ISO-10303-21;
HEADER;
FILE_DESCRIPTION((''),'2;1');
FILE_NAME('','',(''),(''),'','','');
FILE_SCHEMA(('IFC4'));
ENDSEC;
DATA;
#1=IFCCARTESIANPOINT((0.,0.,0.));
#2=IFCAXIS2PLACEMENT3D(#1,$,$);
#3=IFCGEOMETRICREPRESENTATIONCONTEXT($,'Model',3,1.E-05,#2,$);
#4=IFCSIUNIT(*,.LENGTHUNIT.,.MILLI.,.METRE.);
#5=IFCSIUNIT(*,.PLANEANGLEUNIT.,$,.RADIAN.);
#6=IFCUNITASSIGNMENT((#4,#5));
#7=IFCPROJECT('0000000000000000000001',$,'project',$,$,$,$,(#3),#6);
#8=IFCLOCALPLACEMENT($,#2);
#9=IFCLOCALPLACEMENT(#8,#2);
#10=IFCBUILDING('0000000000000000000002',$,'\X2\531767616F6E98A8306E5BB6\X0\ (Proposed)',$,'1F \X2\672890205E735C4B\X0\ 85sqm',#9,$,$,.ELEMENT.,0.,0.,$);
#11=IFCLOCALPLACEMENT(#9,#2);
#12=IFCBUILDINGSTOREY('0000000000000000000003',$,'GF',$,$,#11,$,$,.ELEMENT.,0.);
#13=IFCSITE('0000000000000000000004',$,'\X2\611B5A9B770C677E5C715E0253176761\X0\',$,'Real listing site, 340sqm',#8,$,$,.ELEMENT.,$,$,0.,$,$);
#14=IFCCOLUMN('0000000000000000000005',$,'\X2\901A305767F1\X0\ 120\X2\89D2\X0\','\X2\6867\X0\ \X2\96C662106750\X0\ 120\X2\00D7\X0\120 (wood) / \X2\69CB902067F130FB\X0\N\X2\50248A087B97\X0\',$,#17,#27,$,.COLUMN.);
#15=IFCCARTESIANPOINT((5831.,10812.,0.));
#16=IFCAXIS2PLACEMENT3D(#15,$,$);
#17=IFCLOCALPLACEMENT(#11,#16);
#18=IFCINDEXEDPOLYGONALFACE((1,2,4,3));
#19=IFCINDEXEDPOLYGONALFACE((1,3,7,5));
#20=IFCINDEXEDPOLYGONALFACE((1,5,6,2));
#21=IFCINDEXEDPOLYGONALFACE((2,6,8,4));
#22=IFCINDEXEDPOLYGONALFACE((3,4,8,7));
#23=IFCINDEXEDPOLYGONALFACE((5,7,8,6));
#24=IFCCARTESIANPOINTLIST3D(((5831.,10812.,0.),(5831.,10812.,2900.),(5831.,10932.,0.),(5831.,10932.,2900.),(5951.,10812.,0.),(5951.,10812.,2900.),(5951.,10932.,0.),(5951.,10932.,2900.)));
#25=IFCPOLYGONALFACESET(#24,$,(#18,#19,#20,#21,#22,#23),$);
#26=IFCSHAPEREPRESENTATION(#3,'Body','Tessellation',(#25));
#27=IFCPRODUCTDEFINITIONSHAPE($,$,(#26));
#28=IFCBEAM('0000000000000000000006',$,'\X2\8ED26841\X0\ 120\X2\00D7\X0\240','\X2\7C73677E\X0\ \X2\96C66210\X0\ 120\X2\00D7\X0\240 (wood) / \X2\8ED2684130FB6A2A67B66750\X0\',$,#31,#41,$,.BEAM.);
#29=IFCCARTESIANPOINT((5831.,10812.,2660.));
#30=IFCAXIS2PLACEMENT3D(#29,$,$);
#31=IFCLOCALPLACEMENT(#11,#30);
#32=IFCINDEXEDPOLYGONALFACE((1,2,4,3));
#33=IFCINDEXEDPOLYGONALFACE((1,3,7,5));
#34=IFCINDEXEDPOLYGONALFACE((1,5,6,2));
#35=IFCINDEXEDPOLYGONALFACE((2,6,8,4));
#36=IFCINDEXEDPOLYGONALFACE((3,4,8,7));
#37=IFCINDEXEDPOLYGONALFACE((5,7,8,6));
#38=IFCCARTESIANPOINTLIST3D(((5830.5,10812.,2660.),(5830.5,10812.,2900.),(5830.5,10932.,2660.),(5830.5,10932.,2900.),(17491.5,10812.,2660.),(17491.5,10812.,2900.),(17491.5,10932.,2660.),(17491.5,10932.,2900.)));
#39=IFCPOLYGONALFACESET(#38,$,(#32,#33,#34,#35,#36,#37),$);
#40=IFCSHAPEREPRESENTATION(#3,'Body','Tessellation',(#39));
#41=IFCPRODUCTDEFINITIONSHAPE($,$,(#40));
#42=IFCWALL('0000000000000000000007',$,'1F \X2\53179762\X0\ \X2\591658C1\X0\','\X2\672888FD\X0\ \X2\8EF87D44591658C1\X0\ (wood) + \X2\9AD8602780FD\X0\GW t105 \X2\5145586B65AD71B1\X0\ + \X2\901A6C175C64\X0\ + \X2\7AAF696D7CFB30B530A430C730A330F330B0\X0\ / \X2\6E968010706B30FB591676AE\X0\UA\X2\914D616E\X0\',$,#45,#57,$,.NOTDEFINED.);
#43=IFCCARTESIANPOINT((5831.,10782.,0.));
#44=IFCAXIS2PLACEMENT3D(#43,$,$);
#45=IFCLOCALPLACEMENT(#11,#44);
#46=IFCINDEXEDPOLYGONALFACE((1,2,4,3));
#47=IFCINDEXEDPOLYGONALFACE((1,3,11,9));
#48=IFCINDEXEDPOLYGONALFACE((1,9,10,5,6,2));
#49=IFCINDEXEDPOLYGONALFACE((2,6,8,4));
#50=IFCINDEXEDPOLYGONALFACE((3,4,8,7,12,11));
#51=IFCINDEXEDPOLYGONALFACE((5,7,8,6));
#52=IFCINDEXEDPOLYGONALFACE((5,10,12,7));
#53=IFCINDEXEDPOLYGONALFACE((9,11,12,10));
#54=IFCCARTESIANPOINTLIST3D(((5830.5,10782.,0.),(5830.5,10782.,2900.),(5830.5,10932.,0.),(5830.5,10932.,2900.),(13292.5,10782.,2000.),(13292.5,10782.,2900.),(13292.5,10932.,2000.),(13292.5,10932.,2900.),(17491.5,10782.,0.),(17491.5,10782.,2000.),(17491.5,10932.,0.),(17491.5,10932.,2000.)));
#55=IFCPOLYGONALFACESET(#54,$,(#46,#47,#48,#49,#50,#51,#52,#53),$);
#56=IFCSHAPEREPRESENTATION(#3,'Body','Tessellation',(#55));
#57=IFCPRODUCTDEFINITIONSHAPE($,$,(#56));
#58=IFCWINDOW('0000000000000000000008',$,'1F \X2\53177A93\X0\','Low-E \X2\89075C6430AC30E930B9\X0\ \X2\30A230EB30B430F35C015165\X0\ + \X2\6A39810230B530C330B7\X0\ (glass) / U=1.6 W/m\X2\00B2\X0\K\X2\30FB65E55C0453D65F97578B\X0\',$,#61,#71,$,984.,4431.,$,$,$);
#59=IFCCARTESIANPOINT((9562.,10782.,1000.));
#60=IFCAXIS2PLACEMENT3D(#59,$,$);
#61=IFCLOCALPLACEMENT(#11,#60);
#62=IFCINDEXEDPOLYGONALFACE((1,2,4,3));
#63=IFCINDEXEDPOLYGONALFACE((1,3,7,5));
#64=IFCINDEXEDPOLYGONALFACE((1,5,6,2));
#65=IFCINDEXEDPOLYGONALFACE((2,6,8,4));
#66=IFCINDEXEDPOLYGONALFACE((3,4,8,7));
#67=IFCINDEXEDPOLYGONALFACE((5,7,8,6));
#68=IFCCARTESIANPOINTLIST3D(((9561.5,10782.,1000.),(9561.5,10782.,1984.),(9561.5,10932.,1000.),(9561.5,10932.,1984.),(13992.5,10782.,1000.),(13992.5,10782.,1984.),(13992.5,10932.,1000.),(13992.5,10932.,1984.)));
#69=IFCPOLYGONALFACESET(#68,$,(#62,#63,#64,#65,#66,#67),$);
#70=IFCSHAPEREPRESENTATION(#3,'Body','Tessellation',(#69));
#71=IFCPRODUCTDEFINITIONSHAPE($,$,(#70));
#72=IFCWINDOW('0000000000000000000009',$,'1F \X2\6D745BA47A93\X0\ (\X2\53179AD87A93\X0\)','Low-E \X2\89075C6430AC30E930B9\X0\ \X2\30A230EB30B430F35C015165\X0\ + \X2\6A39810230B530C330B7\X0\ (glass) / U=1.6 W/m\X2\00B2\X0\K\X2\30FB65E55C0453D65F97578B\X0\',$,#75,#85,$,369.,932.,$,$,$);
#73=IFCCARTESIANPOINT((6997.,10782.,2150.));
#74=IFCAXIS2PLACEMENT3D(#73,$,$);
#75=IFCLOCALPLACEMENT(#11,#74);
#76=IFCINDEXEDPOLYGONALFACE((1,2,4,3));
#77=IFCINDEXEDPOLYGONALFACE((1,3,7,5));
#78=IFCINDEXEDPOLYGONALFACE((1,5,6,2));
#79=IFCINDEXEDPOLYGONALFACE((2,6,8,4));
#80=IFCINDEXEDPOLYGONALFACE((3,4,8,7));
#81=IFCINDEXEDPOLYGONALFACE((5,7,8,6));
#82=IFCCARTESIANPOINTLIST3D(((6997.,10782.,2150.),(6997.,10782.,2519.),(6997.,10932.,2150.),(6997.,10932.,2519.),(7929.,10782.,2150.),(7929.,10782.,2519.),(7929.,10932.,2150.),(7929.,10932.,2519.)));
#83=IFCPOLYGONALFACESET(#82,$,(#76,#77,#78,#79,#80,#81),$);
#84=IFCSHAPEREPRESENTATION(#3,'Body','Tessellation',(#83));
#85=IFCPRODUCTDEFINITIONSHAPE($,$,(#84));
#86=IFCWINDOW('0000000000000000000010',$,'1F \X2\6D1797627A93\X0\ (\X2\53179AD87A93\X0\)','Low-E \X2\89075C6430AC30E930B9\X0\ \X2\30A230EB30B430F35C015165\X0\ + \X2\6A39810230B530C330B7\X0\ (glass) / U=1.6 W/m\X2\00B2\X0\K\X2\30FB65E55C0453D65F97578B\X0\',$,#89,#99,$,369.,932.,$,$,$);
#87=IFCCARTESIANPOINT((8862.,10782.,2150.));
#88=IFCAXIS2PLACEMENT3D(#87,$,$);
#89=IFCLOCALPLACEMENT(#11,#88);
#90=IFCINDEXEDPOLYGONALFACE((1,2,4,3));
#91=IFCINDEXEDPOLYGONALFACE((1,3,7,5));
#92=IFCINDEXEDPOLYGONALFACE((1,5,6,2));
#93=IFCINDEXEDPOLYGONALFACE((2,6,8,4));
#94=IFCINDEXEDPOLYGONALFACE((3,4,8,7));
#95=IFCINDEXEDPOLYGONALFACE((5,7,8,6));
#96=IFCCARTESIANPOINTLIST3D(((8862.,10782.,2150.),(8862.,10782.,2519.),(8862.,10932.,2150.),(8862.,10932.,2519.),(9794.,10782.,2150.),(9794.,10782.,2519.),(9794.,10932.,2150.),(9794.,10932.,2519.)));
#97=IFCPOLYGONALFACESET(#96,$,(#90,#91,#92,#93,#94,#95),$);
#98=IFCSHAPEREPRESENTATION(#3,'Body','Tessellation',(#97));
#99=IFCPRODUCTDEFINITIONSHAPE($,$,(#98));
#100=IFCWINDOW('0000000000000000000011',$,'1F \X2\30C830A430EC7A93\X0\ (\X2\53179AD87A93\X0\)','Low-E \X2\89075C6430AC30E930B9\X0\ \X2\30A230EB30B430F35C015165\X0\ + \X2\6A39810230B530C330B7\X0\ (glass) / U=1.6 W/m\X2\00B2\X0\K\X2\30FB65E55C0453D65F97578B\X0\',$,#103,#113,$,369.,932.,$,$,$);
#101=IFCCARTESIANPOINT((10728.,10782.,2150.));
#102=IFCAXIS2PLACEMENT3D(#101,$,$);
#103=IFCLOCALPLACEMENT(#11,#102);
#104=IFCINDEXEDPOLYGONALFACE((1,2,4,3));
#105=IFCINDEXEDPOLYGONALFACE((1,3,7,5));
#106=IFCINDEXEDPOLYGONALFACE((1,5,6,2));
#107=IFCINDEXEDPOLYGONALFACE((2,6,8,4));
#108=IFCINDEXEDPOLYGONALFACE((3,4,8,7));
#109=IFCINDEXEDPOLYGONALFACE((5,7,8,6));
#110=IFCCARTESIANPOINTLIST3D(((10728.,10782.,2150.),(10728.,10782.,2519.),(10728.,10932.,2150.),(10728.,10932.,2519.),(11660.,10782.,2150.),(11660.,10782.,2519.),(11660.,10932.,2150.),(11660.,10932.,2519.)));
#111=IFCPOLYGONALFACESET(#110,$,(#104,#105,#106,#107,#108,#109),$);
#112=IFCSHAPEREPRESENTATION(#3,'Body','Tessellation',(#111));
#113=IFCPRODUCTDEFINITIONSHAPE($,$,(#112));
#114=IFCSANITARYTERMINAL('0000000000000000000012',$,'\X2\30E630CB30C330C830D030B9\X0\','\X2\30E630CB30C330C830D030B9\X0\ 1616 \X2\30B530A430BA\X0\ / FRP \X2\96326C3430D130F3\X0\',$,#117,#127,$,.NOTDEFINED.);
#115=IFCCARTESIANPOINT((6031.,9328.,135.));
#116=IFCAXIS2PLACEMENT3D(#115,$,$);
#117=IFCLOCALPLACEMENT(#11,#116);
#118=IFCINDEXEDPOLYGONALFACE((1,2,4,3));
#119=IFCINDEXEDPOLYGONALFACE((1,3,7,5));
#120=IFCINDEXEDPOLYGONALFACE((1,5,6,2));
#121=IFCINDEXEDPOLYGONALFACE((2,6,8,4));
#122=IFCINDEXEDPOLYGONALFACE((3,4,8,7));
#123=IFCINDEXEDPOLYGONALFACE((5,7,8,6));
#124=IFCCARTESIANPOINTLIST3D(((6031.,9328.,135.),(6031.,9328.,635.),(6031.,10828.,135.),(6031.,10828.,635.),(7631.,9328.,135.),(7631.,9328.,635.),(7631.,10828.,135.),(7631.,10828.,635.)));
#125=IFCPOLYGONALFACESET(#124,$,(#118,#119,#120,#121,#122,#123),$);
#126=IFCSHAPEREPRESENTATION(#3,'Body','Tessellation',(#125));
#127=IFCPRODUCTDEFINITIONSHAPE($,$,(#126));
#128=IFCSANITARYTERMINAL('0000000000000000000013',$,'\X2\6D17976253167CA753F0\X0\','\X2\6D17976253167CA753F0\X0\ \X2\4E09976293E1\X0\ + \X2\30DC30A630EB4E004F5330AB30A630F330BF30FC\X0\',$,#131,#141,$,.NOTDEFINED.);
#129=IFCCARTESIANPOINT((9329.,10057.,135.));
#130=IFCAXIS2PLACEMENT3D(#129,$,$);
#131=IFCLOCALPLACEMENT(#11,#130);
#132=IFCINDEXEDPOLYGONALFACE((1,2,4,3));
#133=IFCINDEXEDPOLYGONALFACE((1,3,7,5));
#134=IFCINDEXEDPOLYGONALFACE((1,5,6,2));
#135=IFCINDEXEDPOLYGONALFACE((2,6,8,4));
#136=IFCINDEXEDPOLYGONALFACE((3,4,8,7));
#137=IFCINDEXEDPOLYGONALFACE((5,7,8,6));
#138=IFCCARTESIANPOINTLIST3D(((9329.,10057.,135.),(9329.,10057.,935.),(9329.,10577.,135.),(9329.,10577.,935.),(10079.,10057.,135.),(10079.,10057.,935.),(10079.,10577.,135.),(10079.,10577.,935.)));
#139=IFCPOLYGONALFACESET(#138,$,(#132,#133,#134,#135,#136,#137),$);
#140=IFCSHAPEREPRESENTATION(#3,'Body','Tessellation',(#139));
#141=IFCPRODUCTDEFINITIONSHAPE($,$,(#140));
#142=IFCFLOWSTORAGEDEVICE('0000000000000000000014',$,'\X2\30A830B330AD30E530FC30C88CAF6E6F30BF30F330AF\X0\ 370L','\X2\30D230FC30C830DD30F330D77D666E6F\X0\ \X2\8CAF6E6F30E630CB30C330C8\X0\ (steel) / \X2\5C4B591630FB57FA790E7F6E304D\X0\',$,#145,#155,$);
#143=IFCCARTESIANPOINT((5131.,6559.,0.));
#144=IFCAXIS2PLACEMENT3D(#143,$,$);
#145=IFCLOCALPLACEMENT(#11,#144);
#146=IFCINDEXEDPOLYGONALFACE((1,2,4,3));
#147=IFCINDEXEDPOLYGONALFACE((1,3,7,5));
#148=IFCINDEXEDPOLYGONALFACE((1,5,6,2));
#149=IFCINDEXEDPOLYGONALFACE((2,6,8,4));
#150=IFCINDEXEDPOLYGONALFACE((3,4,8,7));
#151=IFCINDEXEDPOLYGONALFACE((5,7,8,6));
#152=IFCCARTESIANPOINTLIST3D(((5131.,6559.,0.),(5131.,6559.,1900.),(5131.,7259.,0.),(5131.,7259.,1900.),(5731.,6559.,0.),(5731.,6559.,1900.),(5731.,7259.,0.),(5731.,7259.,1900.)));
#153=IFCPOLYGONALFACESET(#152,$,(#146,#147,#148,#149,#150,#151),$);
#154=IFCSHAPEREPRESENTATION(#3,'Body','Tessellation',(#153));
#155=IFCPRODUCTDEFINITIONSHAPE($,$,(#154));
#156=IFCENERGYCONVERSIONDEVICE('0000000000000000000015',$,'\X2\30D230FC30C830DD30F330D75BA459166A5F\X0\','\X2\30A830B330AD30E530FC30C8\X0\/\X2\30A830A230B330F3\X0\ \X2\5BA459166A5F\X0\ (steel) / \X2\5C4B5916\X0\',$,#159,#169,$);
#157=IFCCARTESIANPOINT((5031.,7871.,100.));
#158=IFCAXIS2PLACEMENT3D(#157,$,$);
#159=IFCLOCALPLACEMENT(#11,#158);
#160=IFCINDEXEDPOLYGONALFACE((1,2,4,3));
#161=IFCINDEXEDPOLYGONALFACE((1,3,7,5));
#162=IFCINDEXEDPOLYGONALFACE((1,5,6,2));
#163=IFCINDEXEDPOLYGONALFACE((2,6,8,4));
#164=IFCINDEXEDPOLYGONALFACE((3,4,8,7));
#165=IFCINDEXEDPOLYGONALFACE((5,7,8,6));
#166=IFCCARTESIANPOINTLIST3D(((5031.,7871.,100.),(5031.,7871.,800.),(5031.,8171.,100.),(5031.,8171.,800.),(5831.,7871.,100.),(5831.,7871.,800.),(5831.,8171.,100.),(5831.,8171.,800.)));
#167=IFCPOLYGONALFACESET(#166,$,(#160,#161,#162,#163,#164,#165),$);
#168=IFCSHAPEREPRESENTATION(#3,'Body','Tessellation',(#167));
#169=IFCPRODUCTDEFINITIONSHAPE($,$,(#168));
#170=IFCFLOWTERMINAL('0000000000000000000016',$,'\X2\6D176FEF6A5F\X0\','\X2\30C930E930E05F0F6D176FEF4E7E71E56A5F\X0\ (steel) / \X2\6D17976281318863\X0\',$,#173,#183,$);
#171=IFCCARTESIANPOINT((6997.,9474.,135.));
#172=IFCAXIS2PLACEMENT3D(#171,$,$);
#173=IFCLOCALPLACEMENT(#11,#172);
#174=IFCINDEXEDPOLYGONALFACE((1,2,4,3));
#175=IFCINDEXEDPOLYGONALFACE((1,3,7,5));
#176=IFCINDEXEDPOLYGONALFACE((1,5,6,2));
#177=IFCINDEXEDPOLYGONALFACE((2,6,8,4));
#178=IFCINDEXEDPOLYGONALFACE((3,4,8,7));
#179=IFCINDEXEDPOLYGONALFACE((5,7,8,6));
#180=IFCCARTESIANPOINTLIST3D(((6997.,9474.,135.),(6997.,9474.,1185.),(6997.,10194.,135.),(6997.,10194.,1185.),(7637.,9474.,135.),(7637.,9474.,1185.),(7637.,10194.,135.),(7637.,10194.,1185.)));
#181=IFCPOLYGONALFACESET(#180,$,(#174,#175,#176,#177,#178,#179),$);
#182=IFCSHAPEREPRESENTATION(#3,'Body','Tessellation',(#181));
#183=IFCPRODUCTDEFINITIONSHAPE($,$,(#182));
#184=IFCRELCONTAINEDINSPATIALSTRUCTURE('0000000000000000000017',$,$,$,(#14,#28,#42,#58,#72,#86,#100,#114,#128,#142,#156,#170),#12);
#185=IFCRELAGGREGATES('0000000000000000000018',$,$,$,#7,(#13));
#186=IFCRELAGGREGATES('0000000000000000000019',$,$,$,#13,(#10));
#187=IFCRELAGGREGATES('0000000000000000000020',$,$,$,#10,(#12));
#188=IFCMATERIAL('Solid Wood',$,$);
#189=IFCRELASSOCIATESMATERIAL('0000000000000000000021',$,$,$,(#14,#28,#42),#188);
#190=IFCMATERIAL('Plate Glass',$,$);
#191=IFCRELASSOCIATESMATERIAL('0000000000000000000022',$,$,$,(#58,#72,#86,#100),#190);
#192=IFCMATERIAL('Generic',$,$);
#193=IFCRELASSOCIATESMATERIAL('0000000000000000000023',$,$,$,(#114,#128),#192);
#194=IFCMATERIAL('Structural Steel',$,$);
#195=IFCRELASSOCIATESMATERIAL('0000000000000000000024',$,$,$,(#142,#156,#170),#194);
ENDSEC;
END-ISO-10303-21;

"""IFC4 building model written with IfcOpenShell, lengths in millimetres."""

from ifc_helpers import new_model, si_unit, frame, frame_2d, origin, place, context, project, spatial, rectangle, extrude, material, element, fill, save


model = new_model("IFC4")

# Units and contexts
model_context = context("Model", 3, precision=1e-05, world=origin())
ifc_project = project(units=[si_unit("LENGTHUNIT", "METRE", prefix="MILLI"), si_unit("PLANEANGLEUNIT", "RADIAN")], contexts=[model_context])

# Site, building, storey
site_placement = place(None, origin())
site = spatial("IfcSite", under=ifc_project, at=site_placement, Name="愛媛県松山市北条", ObjectType="Real listing site, 340sqm", CompositionType="ELEMENT", RefElevation=0.0)
building_placement = place(site_placement, origin())
building = spatial("IfcBuilding", under=site, at=building_placement, Name="北条潮風の家 (Proposed)", ObjectType="1F 木造平屋 85sqm", CompositionType="ELEMENT", ElevationOfRefHeight=0.0, ElevationOfTerrain=0.0)
storey_placement = place(building_placement, origin())
storey = spatial("IfcBuildingStorey", under=building, at=storey_placement, Name="GF", CompositionType="ELEMENT", Elevation=0.0)

# Column
ifc_material_1 = material(Name="Solid Wood")
column_1_placement = place(storey_placement, frame((5831.0, 10812.0, 0.0)))
element("IfcColumn", 1, at=column_1_placement, inside=storey, material=ifc_material_1, Name="通し柱 120角", Description="桧 集成材 120×120 (wood) / 構造柱・N値計算", PredefinedType="COLUMN", context=model_context, shape_type="SweptSolid", body=[
    extrude(rectangle(XDim=120.0, YDim=120.0, at=frame_2d((60.0, 60.0))), frame((5831.0, 10812.0, 0.0)), (0.0, 0.0, 1.0), 2900.0),
])

# Beam
beam_1_placement = place(storey_placement, frame((5831.0, 10812.0, 2660.0)))
element("IfcBeam", 2, at=beam_1_placement, inside=storey, material=ifc_material_1, Name="軒桁 120×240", Description="米松 集成 120×240 (wood) / 軒桁・横架材", PredefinedType="BEAM", context=model_context, shape_type="SweptSolid", body=[
    extrude(rectangle(XDim=11661.0, YDim=120.0, at=frame_2d((5830.0, 60.0))), frame((5831.0, 10812.0, 2660.0)), (0.0, 0.0, 1.0), 240.0),
])

# Wall, openings, windows
wall_1_placement = place(storey_placement, frame((5831.0, 10782.0, 0.0)))
wall_1 = element("IfcWall", 3, at=wall_1_placement, inside=storey, material=ifc_material_1, Name="1F 北面 外壁", Description="木製 軸組外壁 (wood) + 高性能GW t105 充填断熱 + 通気層 + 窯業系サイディング / 準耐火・外皮UA配慮", PredefinedType="NOTDEFINED", context=model_context, shape_type="SweptSolid", body=[
    extrude(rectangle(XDim=11661.0, YDim=150.0, at=frame_2d((5830.0, 75.0))), frame((5831.0, 10782.0, 0.0)), (0.0, 0.0, 1.0), 2900.0),
])
opening_1_placement = place(storey_placement, frame((9562.0, 10782.0, 1000.0)))
opening_1 = element("IfcOpeningElement", 4, at=opening_1_placement, cuts=wall_1, PredefinedType="NOTDEFINED", context=model_context, shape_type="SweptSolid", body=[
    extrude(rectangle(XDim=4431.0, YDim=150.0, at=frame_2d((2215.0, 75.0))), frame((9562.0, 10782.0, 1000.0)), (0.0, 0.0, 1.0), 984.0),
])
opening_2_placement = place(storey_placement, frame((6997.0, 10782.0, 2150.0)))
opening_2 = element("IfcOpeningElement", 5, at=opening_2_placement, cuts=wall_1, PredefinedType="NOTDEFINED", context=model_context, shape_type="SweptSolid", body=[
    extrude(rectangle(XDim=932.0, YDim=150.0, at=frame_2d((466.0, 75.0))), frame((6997.0, 10782.0, 2150.0)), (0.0, 0.0, 1.0), 369.0),
])
opening_3_placement = place(storey_placement, frame((8862.0, 10782.0, 2150.0)))
opening_3 = element("IfcOpeningElement", 6, at=opening_3_placement, cuts=wall_1, PredefinedType="NOTDEFINED", context=model_context, shape_type="SweptSolid", body=[
    extrude(rectangle(XDim=932.0, YDim=150.0, at=frame_2d((466.0, 75.0))), frame((8862.0, 10782.0, 2150.0)), (0.0, 0.0, 1.0), 369.0),
])
opening_4_placement = place(storey_placement, frame((10728.0, 10782.0, 2150.0)))
opening_4 = element("IfcOpeningElement", 7, at=opening_4_placement, cuts=wall_1, PredefinedType="NOTDEFINED", context=model_context, shape_type="SweptSolid", body=[
    extrude(rectangle(XDim=932.0, YDim=150.0, at=frame_2d((466.0, 75.0))), frame((10728.0, 10782.0, 2150.0)), (0.0, 0.0, 1.0), 369.0),
])
ifc_material_2 = material(Name="Plate Glass")
window_1_placement = place(storey_placement, frame((9562.0, 10782.0, 1000.0)))
window_1 = element("IfcWindow", 8, at=window_1_placement, inside=storey, material=ifc_material_2, Name="1F 北窓", Description="Low-E 複層ガラス アルゴン封入 + 樹脂サッシ (glass) / U=1.6 W/m²K・日射取得型", OverallHeight=984.0, OverallWidth=4431.0, context=model_context, shape_type="SweptSolid", body=[
    extrude(rectangle(XDim=4431.0, YDim=150.0, at=frame_2d((2215.0, 75.0))), frame((9562.0, 10782.0, 1000.0)), (0.0, 0.0, 1.0), 984.0),
])
fill(opening_1, window_1)
window_2_placement = place(storey_placement, frame((6997.0, 10782.0, 2150.0)))
window_2 = element("IfcWindow", 9, at=window_2_placement, inside=storey, material=ifc_material_2, Name="1F 浴室窓 (北高窓)", Description="Low-E 複層ガラス アルゴン封入 + 樹脂サッシ (glass) / U=1.6 W/m²K・日射取得型", OverallHeight=369.0, OverallWidth=932.0, context=model_context, shape_type="SweptSolid", body=[
    extrude(rectangle(XDim=932.0, YDim=150.0, at=frame_2d((466.0, 75.0))), frame((6997.0, 10782.0, 2150.0)), (0.0, 0.0, 1.0), 369.0),
])
fill(opening_2, window_2)
window_3_placement = place(storey_placement, frame((8862.0, 10782.0, 2150.0)))
window_3 = element("IfcWindow", 10, at=window_3_placement, inside=storey, material=ifc_material_2, Name="1F 洗面窓 (北高窓)", Description="Low-E 複層ガラス アルゴン封入 + 樹脂サッシ (glass) / U=1.6 W/m²K・日射取得型", OverallHeight=369.0, OverallWidth=932.0, context=model_context, shape_type="SweptSolid", body=[
    extrude(rectangle(XDim=932.0, YDim=150.0, at=frame_2d((466.0, 75.0))), frame((8862.0, 10782.0, 2150.0)), (0.0, 0.0, 1.0), 369.0),
])
fill(opening_3, window_3)
window_4_placement = place(storey_placement, frame((10728.0, 10782.0, 2150.0)))
window_4 = element("IfcWindow", 11, at=window_4_placement, inside=storey, material=ifc_material_2, Name="1F トイレ窓 (北高窓)", Description="Low-E 複層ガラス アルゴン封入 + 樹脂サッシ (glass) / U=1.6 W/m²K・日射取得型", OverallHeight=369.0, OverallWidth=932.0, context=model_context, shape_type="SweptSolid", body=[
    extrude(rectangle(XDim=932.0, YDim=150.0, at=frame_2d((466.0, 75.0))), frame((10728.0, 10782.0, 2150.0)), (0.0, 0.0, 1.0), 369.0),
])
fill(opening_4, window_4)

# Sanitary terminals
ifc_material_3 = material(Name="Generic")
sanitary_terminal_1_placement = place(storey_placement, frame((6031.0, 9328.0, 135.0)))
element("IfcSanitaryTerminal", 12, at=sanitary_terminal_1_placement, inside=storey, material=ifc_material_3, Name="ユニットバス", Description="ユニットバス 1616 サイズ / FRP 防水パン", PredefinedType="NOTDEFINED", context=model_context, shape_type="SweptSolid", body=[
    extrude(rectangle(XDim=1600.0, YDim=1500.0, at=frame_2d((800.0, 750.0))), frame((6031.0, 9328.0, 135.0)), (0.0, 0.0, 1.0), 500.0),
])
sanitary_terminal_2_placement = place(storey_placement, frame((9329.0, 10057.0, 135.0)))
element("IfcSanitaryTerminal", 13, at=sanitary_terminal_2_placement, inside=storey, material=ifc_material_3, Name="洗面化粧台", Description="洗面化粧台 三面鏡 + ボウル一体カウンター", PredefinedType="NOTDEFINED", context=model_context, shape_type="SweptSolid", body=[
    extrude(rectangle(XDim=750.0, YDim=520.0, at=frame_2d((375.0, 260.0))), frame((9329.0, 10057.0, 135.0)), (0.0, 0.0, 1.0), 800.0),
])

# Flow storage device
ifc_material_4 = material(Name="Structural Steel")
flow_storage_device_placement = place(storey_placement, frame((5131.0, 6559.0, 0.0)))
element("IfcFlowStorageDevice", 14, at=flow_storage_device_placement, inside=storey, material=ifc_material_4, Name="エコキュート貯湯タンク 370L", Description="ヒートポンプ給湯 貯湯ユニット (steel) / 屋外・基礎置き", context=model_context, shape_type="SweptSolid", body=[
    extrude(rectangle(XDim=600.0, YDim=700.0, at=frame_2d((300.0, 350.0))), frame((5131.0, 6559.0, 0.0)), (0.0, 0.0, 1.0), 1900.0),
])

# Energy conversion device
energy_conversion_device_placement = place(storey_placement, frame((5031.0, 7871.0, 100.0)))
element("IfcEnergyConversionDevice", 15, at=energy_conversion_device_placement, inside=storey, material=ifc_material_4, Name="ヒートポンプ室外機", Description="エコキュート/エアコン 室外機 (steel) / 屋外", context=model_context, shape_type="SweptSolid", body=[
    extrude(rectangle(XDim=800.0, YDim=300.0, at=frame_2d((400.0, 150.0))), frame((5031.0, 7871.0, 100.0)), (0.0, 0.0, 1.0), 700.0),
])

# Flow terminal
flow_terminal_placement = place(storey_placement, frame((6997.0, 9474.0, 135.0)))
element("IfcFlowTerminal", 16, at=flow_terminal_placement, inside=storey, material=ifc_material_4, Name="洗濯機", Description="ドラム式洗濯乾燥機 (steel) / 洗面脱衣", context=model_context, shape_type="SweptSolid", body=[
    extrude(rectangle(XDim=640.0, YDim=720.0, at=frame_2d((320.0, 360.0))), frame((6997.0, 9474.0, 135.0)), (0.0, 0.0, 1.0), 1050.0),
])

save(model, "model.ifc")
